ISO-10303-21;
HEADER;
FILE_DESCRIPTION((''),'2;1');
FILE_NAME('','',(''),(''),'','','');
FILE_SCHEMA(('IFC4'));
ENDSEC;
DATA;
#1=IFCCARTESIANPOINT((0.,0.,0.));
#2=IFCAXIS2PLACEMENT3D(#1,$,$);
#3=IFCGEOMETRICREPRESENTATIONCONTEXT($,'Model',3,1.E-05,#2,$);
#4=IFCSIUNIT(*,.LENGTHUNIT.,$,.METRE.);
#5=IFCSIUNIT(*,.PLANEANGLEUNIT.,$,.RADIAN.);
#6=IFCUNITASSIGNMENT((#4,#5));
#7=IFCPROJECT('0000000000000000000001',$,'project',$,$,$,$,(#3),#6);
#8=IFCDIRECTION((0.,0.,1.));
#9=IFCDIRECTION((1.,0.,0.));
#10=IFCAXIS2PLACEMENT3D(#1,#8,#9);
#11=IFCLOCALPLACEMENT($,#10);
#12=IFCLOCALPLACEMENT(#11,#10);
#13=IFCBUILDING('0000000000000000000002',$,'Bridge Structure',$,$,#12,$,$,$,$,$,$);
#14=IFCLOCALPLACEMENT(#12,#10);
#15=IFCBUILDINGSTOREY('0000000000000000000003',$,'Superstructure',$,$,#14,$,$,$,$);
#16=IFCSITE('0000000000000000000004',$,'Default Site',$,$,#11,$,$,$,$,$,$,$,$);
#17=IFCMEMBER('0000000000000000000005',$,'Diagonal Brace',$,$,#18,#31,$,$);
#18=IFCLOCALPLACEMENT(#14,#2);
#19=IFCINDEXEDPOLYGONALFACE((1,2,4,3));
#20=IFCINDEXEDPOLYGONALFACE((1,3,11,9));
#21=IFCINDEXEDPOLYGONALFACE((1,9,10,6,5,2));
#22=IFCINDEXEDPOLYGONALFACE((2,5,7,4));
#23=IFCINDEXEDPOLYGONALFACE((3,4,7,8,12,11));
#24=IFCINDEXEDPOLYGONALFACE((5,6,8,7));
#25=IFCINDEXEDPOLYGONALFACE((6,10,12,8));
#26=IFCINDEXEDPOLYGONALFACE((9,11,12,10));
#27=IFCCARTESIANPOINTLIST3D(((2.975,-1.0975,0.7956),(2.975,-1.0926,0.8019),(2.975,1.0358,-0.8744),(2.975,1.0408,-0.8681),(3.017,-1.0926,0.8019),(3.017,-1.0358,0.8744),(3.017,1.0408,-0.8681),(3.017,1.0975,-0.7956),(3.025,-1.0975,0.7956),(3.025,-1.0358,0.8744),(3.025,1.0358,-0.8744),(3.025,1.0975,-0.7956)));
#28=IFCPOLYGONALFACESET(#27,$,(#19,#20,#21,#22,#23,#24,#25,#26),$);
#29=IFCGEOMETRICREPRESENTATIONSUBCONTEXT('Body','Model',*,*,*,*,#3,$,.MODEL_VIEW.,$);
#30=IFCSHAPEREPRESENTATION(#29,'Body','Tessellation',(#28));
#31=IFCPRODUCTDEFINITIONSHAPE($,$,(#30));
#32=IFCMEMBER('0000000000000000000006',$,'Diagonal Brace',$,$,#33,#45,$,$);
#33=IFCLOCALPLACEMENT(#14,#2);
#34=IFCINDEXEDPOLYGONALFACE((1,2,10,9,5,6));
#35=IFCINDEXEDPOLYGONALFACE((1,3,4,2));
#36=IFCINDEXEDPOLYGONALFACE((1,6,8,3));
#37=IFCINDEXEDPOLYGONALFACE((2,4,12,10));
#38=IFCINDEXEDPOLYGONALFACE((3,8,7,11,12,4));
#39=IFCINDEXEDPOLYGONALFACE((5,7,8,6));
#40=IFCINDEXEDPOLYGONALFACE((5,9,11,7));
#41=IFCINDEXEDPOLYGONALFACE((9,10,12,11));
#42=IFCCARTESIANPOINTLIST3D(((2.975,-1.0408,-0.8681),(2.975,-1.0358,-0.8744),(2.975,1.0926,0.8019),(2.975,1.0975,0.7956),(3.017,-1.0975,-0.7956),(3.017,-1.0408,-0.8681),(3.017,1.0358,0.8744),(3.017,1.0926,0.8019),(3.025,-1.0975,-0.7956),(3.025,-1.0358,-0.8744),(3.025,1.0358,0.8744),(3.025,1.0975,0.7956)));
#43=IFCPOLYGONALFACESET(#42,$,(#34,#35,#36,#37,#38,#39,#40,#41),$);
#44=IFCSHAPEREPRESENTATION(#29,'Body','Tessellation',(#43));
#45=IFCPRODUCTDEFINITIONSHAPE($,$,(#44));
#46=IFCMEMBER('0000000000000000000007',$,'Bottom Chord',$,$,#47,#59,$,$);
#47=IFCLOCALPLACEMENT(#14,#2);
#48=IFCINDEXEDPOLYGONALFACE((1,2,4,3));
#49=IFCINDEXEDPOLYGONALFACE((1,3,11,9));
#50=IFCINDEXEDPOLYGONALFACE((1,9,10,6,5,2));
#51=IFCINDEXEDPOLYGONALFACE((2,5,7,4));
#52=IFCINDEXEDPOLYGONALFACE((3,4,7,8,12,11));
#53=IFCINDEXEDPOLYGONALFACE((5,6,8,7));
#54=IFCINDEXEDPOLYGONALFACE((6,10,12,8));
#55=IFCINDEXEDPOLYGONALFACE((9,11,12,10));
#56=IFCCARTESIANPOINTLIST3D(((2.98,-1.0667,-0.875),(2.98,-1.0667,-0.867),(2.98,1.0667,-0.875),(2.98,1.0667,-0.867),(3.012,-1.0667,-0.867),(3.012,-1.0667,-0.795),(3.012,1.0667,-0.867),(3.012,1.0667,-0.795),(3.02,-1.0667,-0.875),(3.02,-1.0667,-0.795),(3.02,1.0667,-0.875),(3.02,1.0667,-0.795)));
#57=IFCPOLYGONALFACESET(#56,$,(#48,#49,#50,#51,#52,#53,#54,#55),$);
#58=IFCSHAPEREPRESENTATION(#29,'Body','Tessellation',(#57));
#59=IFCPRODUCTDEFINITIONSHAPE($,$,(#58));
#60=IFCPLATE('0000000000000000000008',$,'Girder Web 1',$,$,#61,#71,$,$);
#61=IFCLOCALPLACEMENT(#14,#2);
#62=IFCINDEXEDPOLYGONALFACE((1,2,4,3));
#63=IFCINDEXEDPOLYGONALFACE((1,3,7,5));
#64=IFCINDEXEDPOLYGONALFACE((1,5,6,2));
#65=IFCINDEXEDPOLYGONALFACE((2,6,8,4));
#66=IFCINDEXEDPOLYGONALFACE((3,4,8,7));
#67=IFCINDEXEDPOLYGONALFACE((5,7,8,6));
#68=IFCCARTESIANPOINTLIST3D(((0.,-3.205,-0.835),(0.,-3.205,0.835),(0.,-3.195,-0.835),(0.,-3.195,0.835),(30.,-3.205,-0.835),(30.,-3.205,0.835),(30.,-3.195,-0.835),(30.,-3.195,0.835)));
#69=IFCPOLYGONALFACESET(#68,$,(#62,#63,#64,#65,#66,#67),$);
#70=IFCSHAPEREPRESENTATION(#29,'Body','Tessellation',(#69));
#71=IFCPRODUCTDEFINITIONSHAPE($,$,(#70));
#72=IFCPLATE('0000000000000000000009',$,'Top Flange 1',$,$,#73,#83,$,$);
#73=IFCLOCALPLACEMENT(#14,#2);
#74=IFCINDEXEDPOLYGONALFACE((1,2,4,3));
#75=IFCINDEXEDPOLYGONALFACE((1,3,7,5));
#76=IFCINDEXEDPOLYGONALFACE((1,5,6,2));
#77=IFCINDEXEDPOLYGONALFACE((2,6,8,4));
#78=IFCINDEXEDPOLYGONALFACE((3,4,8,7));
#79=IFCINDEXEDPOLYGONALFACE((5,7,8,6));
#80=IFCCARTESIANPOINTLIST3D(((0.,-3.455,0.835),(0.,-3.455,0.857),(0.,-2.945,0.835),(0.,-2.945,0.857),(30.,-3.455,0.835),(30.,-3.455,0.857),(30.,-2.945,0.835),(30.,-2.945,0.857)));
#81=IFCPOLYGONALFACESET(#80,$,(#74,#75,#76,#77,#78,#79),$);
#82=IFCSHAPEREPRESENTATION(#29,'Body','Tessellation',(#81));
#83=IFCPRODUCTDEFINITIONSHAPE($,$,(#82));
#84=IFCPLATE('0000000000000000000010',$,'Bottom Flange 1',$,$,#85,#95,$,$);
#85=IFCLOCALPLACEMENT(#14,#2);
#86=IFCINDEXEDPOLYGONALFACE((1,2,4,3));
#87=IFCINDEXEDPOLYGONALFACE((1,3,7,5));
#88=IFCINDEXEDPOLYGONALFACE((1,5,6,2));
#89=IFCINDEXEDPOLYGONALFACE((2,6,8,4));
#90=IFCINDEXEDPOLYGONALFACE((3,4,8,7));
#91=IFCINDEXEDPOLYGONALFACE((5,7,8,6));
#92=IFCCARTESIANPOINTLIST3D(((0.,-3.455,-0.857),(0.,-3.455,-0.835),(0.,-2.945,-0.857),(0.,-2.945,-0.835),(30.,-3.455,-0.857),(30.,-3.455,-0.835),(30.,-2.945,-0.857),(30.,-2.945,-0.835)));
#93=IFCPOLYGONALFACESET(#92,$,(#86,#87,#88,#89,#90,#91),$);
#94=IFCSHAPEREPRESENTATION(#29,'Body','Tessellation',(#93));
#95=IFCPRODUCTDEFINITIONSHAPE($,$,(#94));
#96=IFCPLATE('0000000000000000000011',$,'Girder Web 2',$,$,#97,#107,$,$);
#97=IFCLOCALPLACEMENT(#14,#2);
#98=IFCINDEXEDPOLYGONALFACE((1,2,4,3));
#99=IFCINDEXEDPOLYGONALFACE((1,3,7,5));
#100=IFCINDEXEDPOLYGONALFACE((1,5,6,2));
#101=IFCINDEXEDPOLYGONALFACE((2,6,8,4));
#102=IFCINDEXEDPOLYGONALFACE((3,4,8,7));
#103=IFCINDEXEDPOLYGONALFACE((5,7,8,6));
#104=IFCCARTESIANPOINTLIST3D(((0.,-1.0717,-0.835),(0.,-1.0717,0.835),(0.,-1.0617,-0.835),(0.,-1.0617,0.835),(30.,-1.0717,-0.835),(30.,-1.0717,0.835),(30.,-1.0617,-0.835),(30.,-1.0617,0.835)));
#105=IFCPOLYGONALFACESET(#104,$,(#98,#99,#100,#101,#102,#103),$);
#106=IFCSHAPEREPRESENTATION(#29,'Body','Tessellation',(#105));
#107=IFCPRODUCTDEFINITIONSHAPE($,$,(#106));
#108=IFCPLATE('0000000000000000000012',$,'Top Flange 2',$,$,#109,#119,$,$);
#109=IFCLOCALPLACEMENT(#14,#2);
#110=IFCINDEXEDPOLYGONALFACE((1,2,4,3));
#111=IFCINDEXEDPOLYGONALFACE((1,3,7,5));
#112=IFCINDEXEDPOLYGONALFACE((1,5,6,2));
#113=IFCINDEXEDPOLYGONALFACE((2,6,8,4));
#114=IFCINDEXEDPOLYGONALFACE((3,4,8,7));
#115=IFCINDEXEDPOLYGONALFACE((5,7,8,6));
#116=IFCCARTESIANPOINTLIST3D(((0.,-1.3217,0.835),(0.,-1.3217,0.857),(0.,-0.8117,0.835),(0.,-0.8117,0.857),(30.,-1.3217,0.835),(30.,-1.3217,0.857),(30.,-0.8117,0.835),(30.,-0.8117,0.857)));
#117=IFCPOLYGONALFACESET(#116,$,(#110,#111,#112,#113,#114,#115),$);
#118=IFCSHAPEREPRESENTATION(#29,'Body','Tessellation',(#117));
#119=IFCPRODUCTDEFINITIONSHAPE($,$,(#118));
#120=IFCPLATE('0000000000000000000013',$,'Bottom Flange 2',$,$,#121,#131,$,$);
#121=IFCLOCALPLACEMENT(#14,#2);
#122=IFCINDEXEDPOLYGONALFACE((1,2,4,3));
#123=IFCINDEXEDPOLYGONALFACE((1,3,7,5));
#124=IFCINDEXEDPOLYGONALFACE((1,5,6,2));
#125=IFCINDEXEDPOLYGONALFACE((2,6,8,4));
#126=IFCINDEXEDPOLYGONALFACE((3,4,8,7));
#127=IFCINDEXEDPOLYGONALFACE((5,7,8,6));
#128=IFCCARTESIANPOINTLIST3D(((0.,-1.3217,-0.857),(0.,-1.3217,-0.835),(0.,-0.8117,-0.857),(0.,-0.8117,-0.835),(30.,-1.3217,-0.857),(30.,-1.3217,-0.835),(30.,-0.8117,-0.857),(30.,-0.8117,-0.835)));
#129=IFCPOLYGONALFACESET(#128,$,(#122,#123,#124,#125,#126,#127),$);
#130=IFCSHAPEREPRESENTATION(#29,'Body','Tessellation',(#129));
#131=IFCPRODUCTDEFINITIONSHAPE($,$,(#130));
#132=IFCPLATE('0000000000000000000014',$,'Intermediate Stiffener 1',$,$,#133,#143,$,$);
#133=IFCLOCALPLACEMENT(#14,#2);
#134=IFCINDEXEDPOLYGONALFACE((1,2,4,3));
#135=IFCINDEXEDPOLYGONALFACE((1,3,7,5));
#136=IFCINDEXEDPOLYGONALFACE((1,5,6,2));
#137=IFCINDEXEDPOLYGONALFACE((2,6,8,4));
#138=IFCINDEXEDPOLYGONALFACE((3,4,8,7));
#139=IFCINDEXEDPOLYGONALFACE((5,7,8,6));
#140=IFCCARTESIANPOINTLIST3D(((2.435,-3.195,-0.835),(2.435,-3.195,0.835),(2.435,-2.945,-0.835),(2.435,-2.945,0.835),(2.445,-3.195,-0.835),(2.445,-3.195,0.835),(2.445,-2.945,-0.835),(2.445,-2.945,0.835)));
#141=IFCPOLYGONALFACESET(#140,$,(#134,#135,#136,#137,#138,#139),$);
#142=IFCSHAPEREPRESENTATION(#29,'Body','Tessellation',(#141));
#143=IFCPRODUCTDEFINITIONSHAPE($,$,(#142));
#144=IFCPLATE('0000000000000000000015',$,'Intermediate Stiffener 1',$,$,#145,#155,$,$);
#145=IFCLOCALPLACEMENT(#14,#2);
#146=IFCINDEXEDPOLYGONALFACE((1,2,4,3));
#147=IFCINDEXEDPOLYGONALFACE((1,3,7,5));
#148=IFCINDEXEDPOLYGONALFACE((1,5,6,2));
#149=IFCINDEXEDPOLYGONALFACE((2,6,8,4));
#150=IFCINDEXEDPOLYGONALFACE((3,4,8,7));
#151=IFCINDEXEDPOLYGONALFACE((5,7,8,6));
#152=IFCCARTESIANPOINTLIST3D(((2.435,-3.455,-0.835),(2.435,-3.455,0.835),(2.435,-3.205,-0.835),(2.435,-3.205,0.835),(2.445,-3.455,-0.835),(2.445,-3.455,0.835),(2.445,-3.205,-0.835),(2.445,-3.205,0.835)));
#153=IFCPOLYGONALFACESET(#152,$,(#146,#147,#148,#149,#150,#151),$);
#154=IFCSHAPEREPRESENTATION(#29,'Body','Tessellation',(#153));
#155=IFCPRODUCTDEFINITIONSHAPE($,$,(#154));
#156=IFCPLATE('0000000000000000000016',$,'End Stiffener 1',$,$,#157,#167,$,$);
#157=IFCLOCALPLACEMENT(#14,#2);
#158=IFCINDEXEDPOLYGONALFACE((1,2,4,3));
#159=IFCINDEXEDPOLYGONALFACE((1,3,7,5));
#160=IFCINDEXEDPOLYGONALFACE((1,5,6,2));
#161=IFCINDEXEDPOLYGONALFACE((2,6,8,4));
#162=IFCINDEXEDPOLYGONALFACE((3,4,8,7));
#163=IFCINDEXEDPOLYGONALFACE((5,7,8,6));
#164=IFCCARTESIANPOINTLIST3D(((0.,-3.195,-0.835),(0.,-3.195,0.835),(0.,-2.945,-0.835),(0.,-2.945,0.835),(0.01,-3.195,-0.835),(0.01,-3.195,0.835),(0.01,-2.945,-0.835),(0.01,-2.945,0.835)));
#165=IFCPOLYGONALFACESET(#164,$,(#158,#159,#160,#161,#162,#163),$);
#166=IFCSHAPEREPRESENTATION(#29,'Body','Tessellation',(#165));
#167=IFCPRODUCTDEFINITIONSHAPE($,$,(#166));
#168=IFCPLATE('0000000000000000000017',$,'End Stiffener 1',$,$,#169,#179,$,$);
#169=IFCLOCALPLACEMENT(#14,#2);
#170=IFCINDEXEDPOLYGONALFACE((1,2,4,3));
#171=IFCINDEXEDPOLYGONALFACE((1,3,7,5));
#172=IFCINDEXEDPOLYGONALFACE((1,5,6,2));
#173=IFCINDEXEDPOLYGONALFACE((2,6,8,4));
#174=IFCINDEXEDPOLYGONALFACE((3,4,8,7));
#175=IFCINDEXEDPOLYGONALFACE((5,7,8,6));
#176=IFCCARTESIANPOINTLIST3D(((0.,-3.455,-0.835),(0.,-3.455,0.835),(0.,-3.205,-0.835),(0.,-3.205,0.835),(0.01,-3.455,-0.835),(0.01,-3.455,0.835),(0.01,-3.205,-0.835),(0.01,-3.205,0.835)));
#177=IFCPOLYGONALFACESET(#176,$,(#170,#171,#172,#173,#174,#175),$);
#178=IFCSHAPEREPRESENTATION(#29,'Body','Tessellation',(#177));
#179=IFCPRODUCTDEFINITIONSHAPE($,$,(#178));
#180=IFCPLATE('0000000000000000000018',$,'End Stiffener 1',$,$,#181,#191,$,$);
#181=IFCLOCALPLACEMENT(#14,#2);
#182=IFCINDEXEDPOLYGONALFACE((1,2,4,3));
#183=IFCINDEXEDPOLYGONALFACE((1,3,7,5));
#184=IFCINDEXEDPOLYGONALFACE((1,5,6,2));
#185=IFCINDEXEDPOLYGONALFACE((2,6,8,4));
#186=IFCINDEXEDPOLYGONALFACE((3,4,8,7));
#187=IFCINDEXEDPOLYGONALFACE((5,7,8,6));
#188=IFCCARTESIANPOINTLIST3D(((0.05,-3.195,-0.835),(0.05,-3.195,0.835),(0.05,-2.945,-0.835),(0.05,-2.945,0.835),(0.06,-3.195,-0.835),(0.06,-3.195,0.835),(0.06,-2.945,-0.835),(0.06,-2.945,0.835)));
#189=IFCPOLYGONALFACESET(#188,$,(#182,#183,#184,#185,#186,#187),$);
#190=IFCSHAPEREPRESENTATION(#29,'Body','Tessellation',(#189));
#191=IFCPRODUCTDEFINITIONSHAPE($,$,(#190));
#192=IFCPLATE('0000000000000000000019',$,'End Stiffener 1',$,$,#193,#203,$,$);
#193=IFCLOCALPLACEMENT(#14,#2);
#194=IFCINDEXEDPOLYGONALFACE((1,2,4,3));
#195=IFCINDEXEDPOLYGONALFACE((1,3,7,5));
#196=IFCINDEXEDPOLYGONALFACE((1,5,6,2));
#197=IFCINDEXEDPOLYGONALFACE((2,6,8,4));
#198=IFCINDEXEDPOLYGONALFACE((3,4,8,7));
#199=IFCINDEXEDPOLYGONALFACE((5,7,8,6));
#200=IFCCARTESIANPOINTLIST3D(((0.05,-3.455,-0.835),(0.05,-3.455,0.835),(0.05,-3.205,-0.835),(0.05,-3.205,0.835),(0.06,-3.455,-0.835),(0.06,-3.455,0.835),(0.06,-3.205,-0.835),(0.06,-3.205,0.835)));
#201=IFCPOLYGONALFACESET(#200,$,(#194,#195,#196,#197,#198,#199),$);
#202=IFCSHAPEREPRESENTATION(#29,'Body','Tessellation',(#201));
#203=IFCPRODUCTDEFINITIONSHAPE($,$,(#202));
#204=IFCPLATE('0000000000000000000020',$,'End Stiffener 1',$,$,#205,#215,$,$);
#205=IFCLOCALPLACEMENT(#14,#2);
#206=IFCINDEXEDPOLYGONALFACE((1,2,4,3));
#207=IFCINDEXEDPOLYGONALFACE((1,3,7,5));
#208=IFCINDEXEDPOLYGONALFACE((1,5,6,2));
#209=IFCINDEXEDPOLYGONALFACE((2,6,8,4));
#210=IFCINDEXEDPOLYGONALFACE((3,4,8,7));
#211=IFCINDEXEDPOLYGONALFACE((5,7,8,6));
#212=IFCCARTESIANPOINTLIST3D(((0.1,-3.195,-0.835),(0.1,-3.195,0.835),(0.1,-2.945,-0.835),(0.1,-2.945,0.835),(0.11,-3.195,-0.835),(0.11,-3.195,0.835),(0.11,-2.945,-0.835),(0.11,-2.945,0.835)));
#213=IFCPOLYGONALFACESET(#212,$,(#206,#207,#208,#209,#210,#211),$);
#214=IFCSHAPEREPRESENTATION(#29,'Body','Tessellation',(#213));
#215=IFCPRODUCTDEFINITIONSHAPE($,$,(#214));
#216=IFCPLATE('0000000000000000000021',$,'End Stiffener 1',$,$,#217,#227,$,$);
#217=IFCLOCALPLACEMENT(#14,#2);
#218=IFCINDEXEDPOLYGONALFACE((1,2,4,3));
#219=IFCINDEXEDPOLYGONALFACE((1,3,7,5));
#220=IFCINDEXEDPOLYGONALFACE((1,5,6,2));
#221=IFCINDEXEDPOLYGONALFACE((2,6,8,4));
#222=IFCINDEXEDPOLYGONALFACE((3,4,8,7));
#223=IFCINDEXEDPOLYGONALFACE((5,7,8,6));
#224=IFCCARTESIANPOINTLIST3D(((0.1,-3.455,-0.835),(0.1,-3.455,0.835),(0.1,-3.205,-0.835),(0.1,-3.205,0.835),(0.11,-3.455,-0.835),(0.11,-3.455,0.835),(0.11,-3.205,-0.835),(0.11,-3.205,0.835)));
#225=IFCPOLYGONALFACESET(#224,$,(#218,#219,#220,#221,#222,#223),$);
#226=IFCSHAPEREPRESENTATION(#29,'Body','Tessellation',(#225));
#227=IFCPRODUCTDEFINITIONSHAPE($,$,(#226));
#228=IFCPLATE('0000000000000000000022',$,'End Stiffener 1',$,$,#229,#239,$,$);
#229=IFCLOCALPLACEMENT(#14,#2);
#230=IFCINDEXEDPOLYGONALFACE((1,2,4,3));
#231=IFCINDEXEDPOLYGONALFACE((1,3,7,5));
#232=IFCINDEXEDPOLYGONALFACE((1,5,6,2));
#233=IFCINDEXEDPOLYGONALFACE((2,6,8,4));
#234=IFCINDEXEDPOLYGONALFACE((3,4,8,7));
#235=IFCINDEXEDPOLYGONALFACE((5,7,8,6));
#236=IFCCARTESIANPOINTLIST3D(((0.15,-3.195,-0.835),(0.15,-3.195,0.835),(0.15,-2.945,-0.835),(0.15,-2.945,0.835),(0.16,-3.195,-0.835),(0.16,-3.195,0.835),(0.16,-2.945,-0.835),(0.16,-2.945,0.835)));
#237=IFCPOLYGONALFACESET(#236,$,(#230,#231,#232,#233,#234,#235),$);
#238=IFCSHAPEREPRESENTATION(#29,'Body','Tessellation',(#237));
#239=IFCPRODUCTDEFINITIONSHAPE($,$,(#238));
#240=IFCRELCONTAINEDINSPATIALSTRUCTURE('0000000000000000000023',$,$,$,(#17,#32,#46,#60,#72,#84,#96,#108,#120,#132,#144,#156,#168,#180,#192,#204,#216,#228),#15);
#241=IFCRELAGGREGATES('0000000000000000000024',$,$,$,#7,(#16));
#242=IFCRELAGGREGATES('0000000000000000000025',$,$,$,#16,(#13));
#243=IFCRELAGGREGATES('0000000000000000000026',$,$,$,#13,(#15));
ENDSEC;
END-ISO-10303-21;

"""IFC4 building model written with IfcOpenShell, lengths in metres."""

from ifc_helpers import new_model, si_unit, frame, origin, origin_with_axes, origin_2d_with_axis, place, context, subcontext, project, spatial, rectangle, l_section, extrude, element, save


model = new_model("IFC4")

# Units and contexts
model_context = context("Model", 3, precision=1e-05, world=origin())
body_context = subcontext(model_context, "Body", "Model", "MODEL_VIEW")
ifc_project = project(units=[si_unit("LENGTHUNIT", "METRE"), si_unit("PLANEANGLEUNIT", "RADIAN")], contexts=[model_context])

# Site, building, storey
site_placement = place(None, origin_with_axes())
site = spatial("IfcSite", under=ifc_project, at=site_placement, Name="Default Site")
building_placement = place(site_placement, origin_with_axes())
building = spatial("IfcBuilding", under=site, at=building_placement, Name="Bridge Structure")
storey_placement = place(building_placement, origin_with_axes())
storey = spatial("IfcBuildingStorey", under=building, at=storey_placement, Name="Superstructure")

# Members
for number, where, z_axis, x_axis, name in (
    (1, (3.0, -1.0667, 0.835), (0.0, 0.787427, -0.616408), (-1.0, 0.0, 0.0), "Diagonal Brace"),
    (2, (3.0, -1.0667, -0.835), (0.0, 0.787427, 0.616408), (-1.0, 0.0, 0.0), "Diagonal Brace"),
):
    element("IfcMember", number, at=place(storey_placement, frame(where, z_axis=z_axis, x_axis=x_axis)), inside=storey, Name=name, context=body_context, shape_type="SweptSolid", body=[
        extrude(l_section(Depth=0.1, Width=0.05, Thickness=0.008, at=origin_2d_with_axis()), origin_with_axes(), (0.0, 0.0, 1.0), 2.7092),
    ])
member_1_placement = place(storey_placement, frame((3.0, -1.0667, -0.835), z_axis=(0.0, 1.0, 0.0), x_axis=(-1.0, 0.0, 0.0)))
element("IfcMember", 3, at=member_1_placement, inside=storey, Name="Bottom Chord", context=body_context, shape_type="SweptSolid", body=[
    extrude(l_section(Depth=0.08, Width=0.04, Thickness=0.008, at=origin_2d_with_axis()), origin_with_axes(), (0.0, 0.0, 1.0), 2.1333),
])

# Plates
plate_1_placement = place(storey_placement, frame((0.0, -3.2, 0.0), z_axis=(1.0, 0.0, 0.0), x_axis=(0.0, 1.0, 0.0)))
element("IfcPlate", 4, at=plate_1_placement, inside=storey, Name="Girder Web 1", context=body_context, shape_type="SweptSolid", body=[
    extrude(rectangle(XDim=0.01, YDim=1.67, at=origin_2d_with_axis()), origin_with_axes(), (0.0, 0.0, 1.0), 30.0),
])
for number, where, z_axis, x_axis, name in (
    (5, (0.0, -3.2, 0.846), (1.0, 0.0, 0.0), (0.0, 1.0, 0.0), "Top Flange 1"),
    (6, (0.0, -3.2, -0.846), (1.0, 0.0, 0.0), (0.0, 1.0, 0.0), "Bottom Flange 1"),
):
    element("IfcPlate", number, at=place(storey_placement, frame(where, z_axis=z_axis, x_axis=x_axis)), inside=storey, Name=name, context=body_context, shape_type="SweptSolid", body=[
        extrude(rectangle(XDim=0.51, YDim=0.022, at=origin_2d_with_axis()), origin_with_axes(), (0.0, 0.0, 1.0), 30.0),
    ])
plate_2_placement = place(storey_placement, frame((0.0, -1.0667, 0.0), z_axis=(1.0, 0.0, 0.0), x_axis=(0.0, 1.0, 0.0)))
element("IfcPlate", 7, at=plate_2_placement, inside=storey, Name="Girder Web 2", context=body_context, shape_type="SweptSolid", body=[
    extrude(rectangle(XDim=0.01, YDim=1.67, at=origin_2d_with_axis()), origin_with_axes(), (0.0, 0.0, 1.0), 30.0),
])
for number, where, z_axis, x_axis, name in (
    (8, (0.0, -1.0667, 0.846), (1.0, 0.0, 0.0), (0.0, 1.0, 0.0), "Top Flange 2"),
    (9, (0.0, -1.0667, -0.846), (1.0, 0.0, 0.0), (0.0, 1.0, 0.0), "Bottom Flange 2"),
):
    element("IfcPlate", number, at=place(storey_placement, frame(where, z_axis=z_axis, x_axis=x_axis)), inside=storey, Name=name, context=body_context, shape_type="SweptSolid", body=[
        extrude(rectangle(XDim=0.51, YDim=0.022, at=origin_2d_with_axis()), origin_with_axes(), (0.0, 0.0, 1.0), 30.0),
    ])
for number, where, z_axis, x_axis, name in (
    (10, (2.44, -3.07, -0.835), (0.0, 0.0, 1.0), (1.0, 0.0, 0.0), "Intermediate Stiffener 1"),
    (11, (2.44, -3.33, -0.835), (0.0, 0.0, 1.0), (1.0, 0.0, 0.0), "Intermediate Stiffener 1"),
    (12, (0.005, -3.07, -0.835), (0.0, 0.0, 1.0), (1.0, 0.0, 0.0), "End Stiffener 1"),
    (13, (0.005, -3.33, -0.835), (0.0, 0.0, 1.0), (1.0, 0.0, 0.0), "End Stiffener 1"),
    (14, (0.055, -3.07, -0.835), (0.0, 0.0, 1.0), (1.0, 0.0, 0.0), "End Stiffener 1"),
    (15, (0.055, -3.33, -0.835), (0.0, 0.0, 1.0), (1.0, 0.0, 0.0), "End Stiffener 1"),
    (16, (0.105, -3.07, -0.835), (0.0, 0.0, 1.0), (1.0, 0.0, 0.0), "End Stiffener 1"),
    (17, (0.105, -3.33, -0.835), (0.0, 0.0, 1.0), (1.0, 0.0, 0.0), "End Stiffener 1"),
    (18, (0.155, -3.07, -0.835), (0.0, 0.0, 1.0), (1.0, 0.0, 0.0), "End Stiffener 1"),
):
    element("IfcPlate", number, at=place(storey_placement, frame(where, z_axis=z_axis, x_axis=x_axis)), inside=storey, Name=name, context=body_context, shape_type="SweptSolid", body=[
        extrude(rectangle(XDim=0.01, YDim=0.25, at=origin_2d_with_axis()), origin_with_axes(), (0.0, 0.0, 1.0), 1.67),
    ])

save(model, "model.ifc")
